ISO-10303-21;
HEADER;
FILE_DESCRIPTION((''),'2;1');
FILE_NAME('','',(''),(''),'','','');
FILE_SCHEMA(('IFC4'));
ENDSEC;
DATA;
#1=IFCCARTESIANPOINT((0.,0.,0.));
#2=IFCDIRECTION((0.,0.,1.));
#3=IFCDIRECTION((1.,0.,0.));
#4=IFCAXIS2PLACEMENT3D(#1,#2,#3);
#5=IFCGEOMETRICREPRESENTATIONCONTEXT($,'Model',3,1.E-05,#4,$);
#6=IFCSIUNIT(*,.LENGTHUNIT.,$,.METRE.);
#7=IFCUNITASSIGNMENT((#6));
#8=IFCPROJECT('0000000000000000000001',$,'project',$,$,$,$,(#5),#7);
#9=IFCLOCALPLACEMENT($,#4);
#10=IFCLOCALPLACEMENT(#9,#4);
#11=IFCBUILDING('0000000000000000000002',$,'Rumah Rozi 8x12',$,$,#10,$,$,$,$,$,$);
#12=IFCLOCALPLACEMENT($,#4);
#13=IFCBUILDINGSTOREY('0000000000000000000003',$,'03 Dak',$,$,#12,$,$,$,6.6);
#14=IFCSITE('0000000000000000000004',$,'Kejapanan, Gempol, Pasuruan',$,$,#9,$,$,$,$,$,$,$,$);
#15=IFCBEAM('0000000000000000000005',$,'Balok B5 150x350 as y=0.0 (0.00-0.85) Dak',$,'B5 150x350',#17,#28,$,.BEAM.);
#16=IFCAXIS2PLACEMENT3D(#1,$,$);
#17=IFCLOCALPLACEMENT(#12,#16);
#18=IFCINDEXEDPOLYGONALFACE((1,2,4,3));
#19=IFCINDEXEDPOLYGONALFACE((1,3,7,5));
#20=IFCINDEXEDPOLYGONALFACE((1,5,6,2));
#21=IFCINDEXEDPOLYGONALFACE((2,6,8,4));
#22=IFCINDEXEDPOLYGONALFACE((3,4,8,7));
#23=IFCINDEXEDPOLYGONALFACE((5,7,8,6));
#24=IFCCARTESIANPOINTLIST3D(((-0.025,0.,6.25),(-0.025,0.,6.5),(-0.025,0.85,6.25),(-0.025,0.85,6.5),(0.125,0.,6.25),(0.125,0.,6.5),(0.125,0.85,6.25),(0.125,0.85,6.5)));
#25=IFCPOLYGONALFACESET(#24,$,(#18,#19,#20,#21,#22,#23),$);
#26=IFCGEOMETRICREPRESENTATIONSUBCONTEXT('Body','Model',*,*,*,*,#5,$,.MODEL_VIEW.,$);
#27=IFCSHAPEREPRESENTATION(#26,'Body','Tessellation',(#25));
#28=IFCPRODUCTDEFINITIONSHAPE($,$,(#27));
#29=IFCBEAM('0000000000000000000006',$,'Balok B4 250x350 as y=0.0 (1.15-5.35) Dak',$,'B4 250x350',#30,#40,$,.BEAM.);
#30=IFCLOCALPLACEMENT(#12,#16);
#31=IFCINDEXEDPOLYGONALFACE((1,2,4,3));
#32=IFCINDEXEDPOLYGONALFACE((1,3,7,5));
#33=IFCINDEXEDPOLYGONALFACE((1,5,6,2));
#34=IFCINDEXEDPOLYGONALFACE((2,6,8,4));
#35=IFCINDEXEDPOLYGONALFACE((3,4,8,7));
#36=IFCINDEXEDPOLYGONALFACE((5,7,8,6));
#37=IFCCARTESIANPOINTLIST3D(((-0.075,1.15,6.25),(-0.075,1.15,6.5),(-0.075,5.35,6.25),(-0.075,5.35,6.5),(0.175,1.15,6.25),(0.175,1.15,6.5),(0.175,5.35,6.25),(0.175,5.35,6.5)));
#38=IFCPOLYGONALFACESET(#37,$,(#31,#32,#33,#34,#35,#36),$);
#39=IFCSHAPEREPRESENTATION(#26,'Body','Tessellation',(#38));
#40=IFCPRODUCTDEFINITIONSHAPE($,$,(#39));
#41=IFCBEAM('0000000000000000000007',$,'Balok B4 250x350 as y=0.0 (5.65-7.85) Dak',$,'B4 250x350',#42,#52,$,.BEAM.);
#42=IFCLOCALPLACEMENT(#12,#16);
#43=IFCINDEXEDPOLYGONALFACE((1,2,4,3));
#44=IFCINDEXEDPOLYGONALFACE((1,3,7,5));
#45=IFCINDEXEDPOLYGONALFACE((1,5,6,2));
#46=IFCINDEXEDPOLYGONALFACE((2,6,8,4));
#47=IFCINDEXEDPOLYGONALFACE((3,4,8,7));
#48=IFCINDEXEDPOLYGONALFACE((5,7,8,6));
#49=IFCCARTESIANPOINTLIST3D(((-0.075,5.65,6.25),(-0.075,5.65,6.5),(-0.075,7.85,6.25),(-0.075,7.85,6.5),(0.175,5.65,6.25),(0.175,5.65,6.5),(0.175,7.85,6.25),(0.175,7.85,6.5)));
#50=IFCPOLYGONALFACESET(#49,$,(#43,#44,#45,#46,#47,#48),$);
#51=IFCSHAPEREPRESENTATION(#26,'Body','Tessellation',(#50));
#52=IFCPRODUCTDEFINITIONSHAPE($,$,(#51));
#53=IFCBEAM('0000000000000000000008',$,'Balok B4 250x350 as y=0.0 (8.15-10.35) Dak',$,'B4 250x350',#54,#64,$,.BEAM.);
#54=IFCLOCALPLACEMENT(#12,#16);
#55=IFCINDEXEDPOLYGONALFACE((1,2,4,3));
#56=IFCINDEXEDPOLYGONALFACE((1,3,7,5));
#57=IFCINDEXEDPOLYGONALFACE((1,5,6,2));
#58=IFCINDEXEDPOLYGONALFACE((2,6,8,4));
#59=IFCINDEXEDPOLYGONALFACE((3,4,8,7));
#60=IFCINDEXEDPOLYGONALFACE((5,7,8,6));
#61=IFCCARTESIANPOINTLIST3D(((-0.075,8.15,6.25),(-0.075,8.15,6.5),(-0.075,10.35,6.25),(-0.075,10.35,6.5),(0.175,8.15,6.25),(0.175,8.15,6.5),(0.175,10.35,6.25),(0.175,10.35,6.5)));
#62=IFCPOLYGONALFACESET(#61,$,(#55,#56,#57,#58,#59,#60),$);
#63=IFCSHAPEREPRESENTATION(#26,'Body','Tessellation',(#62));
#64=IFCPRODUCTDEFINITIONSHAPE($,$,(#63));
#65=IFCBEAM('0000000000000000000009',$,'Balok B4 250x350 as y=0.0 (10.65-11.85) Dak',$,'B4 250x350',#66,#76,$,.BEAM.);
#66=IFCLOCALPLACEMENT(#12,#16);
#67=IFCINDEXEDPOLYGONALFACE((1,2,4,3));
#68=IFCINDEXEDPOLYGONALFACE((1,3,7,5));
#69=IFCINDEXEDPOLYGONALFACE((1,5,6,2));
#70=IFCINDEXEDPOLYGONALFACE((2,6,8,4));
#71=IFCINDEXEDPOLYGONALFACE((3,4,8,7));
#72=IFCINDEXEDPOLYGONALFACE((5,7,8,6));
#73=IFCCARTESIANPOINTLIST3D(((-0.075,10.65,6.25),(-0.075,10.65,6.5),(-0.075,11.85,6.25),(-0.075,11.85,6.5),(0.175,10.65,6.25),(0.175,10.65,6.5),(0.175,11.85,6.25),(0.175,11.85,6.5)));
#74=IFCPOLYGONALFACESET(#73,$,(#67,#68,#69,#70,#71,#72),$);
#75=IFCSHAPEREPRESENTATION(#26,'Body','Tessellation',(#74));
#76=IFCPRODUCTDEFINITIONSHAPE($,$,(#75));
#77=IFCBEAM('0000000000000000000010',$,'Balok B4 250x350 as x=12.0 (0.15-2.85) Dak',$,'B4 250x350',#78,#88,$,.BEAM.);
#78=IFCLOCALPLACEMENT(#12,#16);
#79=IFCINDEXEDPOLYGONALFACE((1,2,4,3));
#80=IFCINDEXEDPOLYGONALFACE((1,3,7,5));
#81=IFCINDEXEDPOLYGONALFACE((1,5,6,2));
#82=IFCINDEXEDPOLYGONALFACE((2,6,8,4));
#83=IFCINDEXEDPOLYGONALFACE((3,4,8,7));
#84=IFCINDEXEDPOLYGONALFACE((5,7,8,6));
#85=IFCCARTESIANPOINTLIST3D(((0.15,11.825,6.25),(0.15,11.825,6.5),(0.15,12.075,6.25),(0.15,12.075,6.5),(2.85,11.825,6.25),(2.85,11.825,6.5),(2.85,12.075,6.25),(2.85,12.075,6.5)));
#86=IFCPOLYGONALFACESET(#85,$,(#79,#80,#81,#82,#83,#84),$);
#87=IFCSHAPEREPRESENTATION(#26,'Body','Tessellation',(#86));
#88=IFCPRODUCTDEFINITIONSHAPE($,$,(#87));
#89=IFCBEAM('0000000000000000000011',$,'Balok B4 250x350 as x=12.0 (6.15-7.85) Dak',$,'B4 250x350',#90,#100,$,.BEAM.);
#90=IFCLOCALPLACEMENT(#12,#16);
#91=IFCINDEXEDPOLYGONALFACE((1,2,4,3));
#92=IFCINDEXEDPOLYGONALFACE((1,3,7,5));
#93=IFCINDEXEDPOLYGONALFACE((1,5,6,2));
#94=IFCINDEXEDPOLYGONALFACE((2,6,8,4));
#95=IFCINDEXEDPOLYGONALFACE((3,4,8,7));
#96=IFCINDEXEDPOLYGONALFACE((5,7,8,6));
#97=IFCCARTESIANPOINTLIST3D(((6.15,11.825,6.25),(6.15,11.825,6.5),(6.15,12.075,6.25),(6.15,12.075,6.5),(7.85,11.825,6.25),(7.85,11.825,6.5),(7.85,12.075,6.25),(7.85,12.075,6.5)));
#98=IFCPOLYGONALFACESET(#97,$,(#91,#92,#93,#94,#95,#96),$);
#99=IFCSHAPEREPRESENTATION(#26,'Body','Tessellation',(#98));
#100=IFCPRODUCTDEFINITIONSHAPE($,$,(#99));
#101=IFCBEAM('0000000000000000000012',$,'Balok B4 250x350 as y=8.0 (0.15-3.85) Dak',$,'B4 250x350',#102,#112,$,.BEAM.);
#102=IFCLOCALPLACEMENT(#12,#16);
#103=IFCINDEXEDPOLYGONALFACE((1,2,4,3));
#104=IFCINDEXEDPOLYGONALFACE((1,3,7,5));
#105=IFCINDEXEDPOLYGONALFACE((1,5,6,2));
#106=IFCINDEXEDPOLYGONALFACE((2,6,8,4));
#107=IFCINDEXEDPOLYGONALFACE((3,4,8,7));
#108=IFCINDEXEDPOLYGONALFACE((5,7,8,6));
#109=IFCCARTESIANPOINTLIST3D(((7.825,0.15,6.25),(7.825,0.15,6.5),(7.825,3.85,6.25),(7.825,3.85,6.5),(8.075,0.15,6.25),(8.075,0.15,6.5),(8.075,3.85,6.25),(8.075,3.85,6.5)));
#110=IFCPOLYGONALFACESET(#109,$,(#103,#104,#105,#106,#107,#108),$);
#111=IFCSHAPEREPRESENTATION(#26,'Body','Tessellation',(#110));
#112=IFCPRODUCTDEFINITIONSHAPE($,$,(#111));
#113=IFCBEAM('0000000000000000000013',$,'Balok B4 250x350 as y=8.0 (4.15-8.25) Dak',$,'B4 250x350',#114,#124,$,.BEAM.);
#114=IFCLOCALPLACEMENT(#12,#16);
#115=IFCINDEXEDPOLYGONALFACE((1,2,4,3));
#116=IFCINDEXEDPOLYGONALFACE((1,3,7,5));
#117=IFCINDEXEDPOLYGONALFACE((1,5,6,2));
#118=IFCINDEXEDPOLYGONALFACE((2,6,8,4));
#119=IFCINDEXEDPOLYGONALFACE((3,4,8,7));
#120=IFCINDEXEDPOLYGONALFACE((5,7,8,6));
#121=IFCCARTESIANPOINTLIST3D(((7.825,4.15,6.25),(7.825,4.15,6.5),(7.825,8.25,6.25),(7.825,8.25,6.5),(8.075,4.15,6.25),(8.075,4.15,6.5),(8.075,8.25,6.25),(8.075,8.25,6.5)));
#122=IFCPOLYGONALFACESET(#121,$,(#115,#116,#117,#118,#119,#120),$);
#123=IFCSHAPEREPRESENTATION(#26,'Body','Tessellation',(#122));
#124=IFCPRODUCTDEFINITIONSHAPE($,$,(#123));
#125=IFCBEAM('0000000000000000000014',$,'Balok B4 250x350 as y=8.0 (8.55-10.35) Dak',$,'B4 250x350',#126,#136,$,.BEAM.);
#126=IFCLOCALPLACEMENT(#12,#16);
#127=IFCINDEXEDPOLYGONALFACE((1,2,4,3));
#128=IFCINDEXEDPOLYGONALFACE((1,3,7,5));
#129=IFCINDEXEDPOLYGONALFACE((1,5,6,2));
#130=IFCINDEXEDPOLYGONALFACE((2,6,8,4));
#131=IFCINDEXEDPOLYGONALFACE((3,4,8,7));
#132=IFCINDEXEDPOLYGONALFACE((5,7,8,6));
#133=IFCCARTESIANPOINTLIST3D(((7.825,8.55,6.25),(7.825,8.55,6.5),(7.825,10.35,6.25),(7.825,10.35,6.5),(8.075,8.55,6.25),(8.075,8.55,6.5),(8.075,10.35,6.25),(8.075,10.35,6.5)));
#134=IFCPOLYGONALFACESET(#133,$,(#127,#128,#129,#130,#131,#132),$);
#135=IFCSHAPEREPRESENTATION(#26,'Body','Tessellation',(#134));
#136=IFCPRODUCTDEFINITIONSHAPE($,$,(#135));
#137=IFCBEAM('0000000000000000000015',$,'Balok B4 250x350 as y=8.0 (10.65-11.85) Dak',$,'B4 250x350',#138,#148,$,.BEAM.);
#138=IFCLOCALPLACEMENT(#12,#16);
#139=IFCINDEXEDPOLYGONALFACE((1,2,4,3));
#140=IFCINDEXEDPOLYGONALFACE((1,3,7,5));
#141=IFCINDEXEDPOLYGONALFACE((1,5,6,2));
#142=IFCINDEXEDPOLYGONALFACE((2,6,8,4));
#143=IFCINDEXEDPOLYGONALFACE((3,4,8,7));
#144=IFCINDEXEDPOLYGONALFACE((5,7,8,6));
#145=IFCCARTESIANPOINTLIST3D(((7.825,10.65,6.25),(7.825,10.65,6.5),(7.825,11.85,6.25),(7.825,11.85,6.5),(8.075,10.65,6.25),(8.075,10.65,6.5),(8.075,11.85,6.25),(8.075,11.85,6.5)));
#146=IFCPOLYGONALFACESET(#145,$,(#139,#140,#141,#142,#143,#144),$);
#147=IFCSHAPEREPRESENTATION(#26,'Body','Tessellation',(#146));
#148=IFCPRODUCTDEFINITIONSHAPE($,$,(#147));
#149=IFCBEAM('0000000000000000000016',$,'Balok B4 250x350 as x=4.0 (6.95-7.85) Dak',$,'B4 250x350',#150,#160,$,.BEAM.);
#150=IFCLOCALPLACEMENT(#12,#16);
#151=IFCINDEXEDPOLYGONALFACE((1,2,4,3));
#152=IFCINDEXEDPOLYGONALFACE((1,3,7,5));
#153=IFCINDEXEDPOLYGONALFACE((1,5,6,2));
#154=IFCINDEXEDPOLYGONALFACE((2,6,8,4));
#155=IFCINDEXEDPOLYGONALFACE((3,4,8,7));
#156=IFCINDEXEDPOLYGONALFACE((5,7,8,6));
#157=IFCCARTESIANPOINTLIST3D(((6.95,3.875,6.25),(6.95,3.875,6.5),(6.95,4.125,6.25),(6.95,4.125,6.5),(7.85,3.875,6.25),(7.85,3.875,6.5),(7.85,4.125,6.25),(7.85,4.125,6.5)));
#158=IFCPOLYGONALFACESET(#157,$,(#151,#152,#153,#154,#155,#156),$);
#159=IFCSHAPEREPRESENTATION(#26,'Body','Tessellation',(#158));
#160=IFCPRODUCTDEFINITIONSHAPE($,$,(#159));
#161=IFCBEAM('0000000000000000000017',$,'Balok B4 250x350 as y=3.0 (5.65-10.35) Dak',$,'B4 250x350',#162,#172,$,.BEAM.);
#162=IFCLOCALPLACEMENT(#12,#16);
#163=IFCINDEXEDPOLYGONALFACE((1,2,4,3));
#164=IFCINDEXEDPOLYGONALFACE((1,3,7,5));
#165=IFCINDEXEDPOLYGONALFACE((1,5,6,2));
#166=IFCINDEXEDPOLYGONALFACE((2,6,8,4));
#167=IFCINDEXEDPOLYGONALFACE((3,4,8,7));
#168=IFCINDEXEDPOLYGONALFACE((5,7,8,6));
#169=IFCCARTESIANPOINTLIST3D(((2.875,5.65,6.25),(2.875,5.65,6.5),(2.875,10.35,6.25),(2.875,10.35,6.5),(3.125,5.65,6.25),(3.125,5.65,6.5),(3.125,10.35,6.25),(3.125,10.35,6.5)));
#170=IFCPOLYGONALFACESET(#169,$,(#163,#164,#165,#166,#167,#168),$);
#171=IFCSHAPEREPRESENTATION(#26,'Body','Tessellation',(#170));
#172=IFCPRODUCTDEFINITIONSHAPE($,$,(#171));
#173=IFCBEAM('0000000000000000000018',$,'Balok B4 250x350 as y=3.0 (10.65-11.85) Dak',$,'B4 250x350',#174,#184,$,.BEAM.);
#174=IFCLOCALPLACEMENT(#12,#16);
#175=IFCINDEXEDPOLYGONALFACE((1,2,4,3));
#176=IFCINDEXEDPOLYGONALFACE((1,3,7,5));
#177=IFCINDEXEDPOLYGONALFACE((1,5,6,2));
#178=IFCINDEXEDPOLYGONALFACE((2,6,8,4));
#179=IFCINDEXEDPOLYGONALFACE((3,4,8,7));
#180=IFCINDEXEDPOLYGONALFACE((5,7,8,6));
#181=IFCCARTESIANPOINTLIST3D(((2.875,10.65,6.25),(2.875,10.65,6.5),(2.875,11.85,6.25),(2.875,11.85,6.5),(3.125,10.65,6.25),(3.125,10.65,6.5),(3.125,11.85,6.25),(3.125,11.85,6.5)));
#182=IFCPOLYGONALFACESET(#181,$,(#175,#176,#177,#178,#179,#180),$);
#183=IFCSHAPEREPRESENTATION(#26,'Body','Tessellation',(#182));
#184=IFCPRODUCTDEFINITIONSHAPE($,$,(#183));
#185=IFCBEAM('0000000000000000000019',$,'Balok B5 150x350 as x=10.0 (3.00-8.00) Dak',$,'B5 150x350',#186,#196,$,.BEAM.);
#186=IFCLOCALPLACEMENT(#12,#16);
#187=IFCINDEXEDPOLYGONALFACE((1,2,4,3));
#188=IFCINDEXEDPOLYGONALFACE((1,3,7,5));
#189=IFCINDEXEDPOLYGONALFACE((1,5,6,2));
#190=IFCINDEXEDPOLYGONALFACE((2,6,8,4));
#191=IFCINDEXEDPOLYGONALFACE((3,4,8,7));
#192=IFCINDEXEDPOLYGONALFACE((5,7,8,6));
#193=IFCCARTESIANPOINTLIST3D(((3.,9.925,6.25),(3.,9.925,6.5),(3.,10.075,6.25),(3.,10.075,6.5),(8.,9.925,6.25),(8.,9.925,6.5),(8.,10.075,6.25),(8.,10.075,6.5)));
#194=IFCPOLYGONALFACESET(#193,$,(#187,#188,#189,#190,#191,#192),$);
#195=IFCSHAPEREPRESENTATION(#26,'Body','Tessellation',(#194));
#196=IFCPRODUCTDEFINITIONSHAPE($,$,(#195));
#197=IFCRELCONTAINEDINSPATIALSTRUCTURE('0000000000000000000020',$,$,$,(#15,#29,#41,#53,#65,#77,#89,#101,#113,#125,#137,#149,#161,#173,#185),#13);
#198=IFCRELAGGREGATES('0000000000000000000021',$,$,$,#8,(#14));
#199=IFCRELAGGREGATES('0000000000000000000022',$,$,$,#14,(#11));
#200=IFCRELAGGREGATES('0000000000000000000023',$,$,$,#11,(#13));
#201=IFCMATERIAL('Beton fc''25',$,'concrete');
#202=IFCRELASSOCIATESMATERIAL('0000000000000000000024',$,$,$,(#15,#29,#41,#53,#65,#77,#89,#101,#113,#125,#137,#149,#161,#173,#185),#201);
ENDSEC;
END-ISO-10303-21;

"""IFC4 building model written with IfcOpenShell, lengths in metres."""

from ifc_helpers import new_model, si_unit, frame, origin_with_axes, place, context, subcontext, project, spatial, line, indexed_curve, outline, extrude, material, element, save


model = new_model("IFC4")

# Units and contexts
model_context = context("Model", 3, precision=1e-05, world=origin_with_axes())
body_context = subcontext(model_context, "Body", "Model", "MODEL_VIEW")
ifc_project = project(units=[si_unit("LENGTHUNIT", "METRE")], contexts=[model_context])

# Site, building, storey
site_placement = place(None, origin_with_axes())
site = spatial("IfcSite", under=ifc_project, at=site_placement, Name="Kejapanan, Gempol, Pasuruan")
building_placement = place(site_placement, origin_with_axes())
building = spatial("IfcBuilding", under=site, at=building_placement, Name="Rumah Rozi 8x12")
storey_placement = place(None, origin_with_axes())
storey = spatial("IfcBuildingStorey", under=building, at=storey_placement, Name="03 Dak", Elevation=6.6)

# Beams
ifc_material = material(Name="Beton fc'25", Category="concrete")
beam_1_placement = place(storey_placement, origin_with_axes())
element("IfcBeam", 1, at=beam_1_placement, inside=storey, material=ifc_material, Name="Balok B5 150x350 as y=0.0 (0.00-0.85) Dak", ObjectType="B5 150x350", PredefinedType="BEAM", context=body_context, shape_type="SweptSolid", body=[
    extrude(outline(indexed_curve([(-0.025, 0.0), (0.125, 0.0), (0.125, 0.85), (-0.025, 0.85)], segments=[line(1, 2, 3, 4, 1)])), frame((0.0, 0.0, 6.25), z_axis=(0.0, 0.0, 1.0), x_axis=(1.0, 0.0, 0.0)), (0.0, 0.0, 1.0), 0.25),
])
beam_2_placement = place(storey_placement, origin_with_axes())
element("IfcBeam", 2, at=beam_2_placement, inside=storey, material=ifc_material, Name="Balok B4 250x350 as y=0.0 (1.15-5.35) Dak", ObjectType="B4 250x350", PredefinedType="BEAM", context=body_context, shape_type="SweptSolid", body=[
    extrude(outline(indexed_curve([(-0.075, 1.15), (0.175, 1.15), (0.175, 5.35), (-0.075, 5.35)], segments=[line(1, 2, 3, 4, 1)])), frame((0.0, 0.0, 6.25), z_axis=(0.0, 0.0, 1.0), x_axis=(1.0, 0.0, 0.0)), (0.0, 0.0, 1.0), 0.25),
])
beam_3_placement = place(storey_placement, origin_with_axes())
element("IfcBeam", 3, at=beam_3_placement, inside=storey, material=ifc_material, Name="Balok B4 250x350 as y=0.0 (5.65-7.85) Dak", ObjectType="B4 250x350", PredefinedType="BEAM", context=body_context, shape_type="SweptSolid", body=[
    extrude(outline(indexed_curve([(-0.075, 5.65), (0.175, 5.65), (0.175, 7.85), (-0.075, 7.85)], segments=[line(1, 2, 3, 4, 1)])), frame((0.0, 0.0, 6.25), z_axis=(0.0, 0.0, 1.0), x_axis=(1.0, 0.0, 0.0)), (0.0, 0.0, 1.0), 0.25),
])
beam_4_placement = place(storey_placement, origin_with_axes())
element("IfcBeam", 4, at=beam_4_placement, inside=storey, material=ifc_material, Name="Balok B4 250x350 as y=0.0 (8.15-10.35) Dak", ObjectType="B4 250x350", PredefinedType="BEAM", context=body_context, shape_type="SweptSolid", body=[
    extrude(outline(indexed_curve([(-0.075, 8.15), (0.175, 8.15), (0.175, 10.35), (-0.075, 10.35)], segments=[line(1, 2, 3, 4, 1)])), frame((0.0, 0.0, 6.25), z_axis=(0.0, 0.0, 1.0), x_axis=(1.0, 0.0, 0.0)), (0.0, 0.0, 1.0), 0.25),
])
beam_5_placement = place(storey_placement, origin_with_axes())
element("IfcBeam", 5, at=beam_5_placement, inside=storey, material=ifc_material, Name="Balok B4 250x350 as y=0.0 (10.65-11.85) Dak", ObjectType="B4 250x350", PredefinedType="BEAM", context=body_context, shape_type="SweptSolid", body=[
    extrude(outline(indexed_curve([(-0.075, 10.65), (0.175, 10.65), (0.175, 11.85), (-0.075, 11.85)], segments=[line(1, 2, 3, 4, 1)])), frame((0.0, 0.0, 6.25), z_axis=(0.0, 0.0, 1.0), x_axis=(1.0, 0.0, 0.0)), (0.0, 0.0, 1.0), 0.25),
])
beam_6_placement = place(storey_placement, origin_with_axes())
element("IfcBeam", 6, at=beam_6_placement, inside=storey, material=ifc_material, Name="Balok B4 250x350 as x=12.0 (0.15-2.85) Dak", ObjectType="B4 250x350", PredefinedType="BEAM", context=body_context, shape_type="SweptSolid", body=[
    extrude(outline(indexed_curve([(0.15, 11.825), (2.85, 11.825), (2.85, 12.075), (0.15, 12.075)], segments=[line(1, 2, 3, 4, 1)])), frame((0.0, 0.0, 6.25), z_axis=(0.0, 0.0, 1.0), x_axis=(1.0, 0.0, 0.0)), (0.0, 0.0, 1.0), 0.25),
])
beam_7_placement = place(storey_placement, origin_with_axes())
element("IfcBeam", 7, at=beam_7_placement, inside=storey, material=ifc_material, Name="Balok B4 250x350 as x=12.0 (6.15-7.85) Dak", ObjectType="B4 250x350", PredefinedType="BEAM", context=body_context, shape_type="SweptSolid", body=[
    extrude(outline(indexed_curve([(6.15, 11.825), (7.85, 11.825), (7.85, 12.075), (6.15, 12.075)], segments=[line(1, 2, 3, 4, 1)])), frame((0.0, 0.0, 6.25), z_axis=(0.0, 0.0, 1.0), x_axis=(1.0, 0.0, 0.0)), (0.0, 0.0, 1.0), 0.25),
])
beam_8_placement = place(storey_placement, origin_with_axes())
element("IfcBeam", 8, at=beam_8_placement, inside=storey, material=ifc_material, Name="Balok B4 250x350 as y=8.0 (0.15-3.85) Dak", ObjectType="B4 250x350", PredefinedType="BEAM", context=body_context, shape_type="SweptSolid", body=[
    extrude(outline(indexed_curve([(7.825, 0.15), (8.075, 0.15), (8.075, 3.85), (7.825, 3.85)], segments=[line(1, 2, 3, 4, 1)])), frame((0.0, 0.0, 6.25), z_axis=(0.0, 0.0, 1.0), x_axis=(1.0, 0.0, 0.0)), (0.0, 0.0, 1.0), 0.25),
])
beam_9_placement = place(storey_placement, origin_with_axes())
element("IfcBeam", 9, at=beam_9_placement, inside=storey, material=ifc_material, Name="Balok B4 250x350 as y=8.0 (4.15-8.25) Dak", ObjectType="B4 250x350", PredefinedType="BEAM", context=body_context, shape_type="SweptSolid", body=[
    extrude(outline(indexed_curve([(7.825, 4.15), (8.075, 4.15), (8.075, 8.25), (7.825, 8.25)], segments=[line(1, 2, 3, 4, 1)])), frame((0.0, 0.0, 6.25), z_axis=(0.0, 0.0, 1.0), x_axis=(1.0, 0.0, 0.0)), (0.0, 0.0, 1.0), 0.25),
])
beam_10_placement = place(storey_placement, origin_with_axes())
element("IfcBeam", 10, at=beam_10_placement, inside=storey, material=ifc_material, Name="Balok B4 250x350 as y=8.0 (8.55-10.35) Dak", ObjectType="B4 250x350", PredefinedType="BEAM", context=body_context, shape_type="SweptSolid", body=[
    extrude(outline(indexed_curve([(7.825, 8.55), (8.075, 8.55), (8.075, 10.35), (7.825, 10.35)], segments=[line(1, 2, 3, 4, 1)])), frame((0.0, 0.0, 6.25), z_axis=(0.0, 0.0, 1.0), x_axis=(1.0, 0.0, 0.0)), (0.0, 0.0, 1.0), 0.25),
])
beam_11_placement = place(storey_placement, origin_with_axes())
element("IfcBeam", 11, at=beam_11_placement, inside=storey, material=ifc_material, Name="Balok B4 250x350 as y=8.0 (10.65-11.85) Dak", ObjectType="B4 250x350", PredefinedType="BEAM", context=body_context, shape_type="SweptSolid", body=[
    extrude(outline(indexed_curve([(7.825, 10.65), (8.075, 10.65), (8.075, 11.85), (7.825, 11.85)], segments=[line(1, 2, 3, 4, 1)])), frame((0.0, 0.0, 6.25), z_axis=(0.0, 0.0, 1.0), x_axis=(1.0, 0.0, 0.0)), (0.0, 0.0, 1.0), 0.25),
])
beam_12_placement = place(storey_placement, origin_with_axes())
element("IfcBeam", 12, at=beam_12_placement, inside=storey, material=ifc_material, Name="Balok B4 250x350 as x=4.0 (6.95-7.85) Dak", ObjectType="B4 250x350", PredefinedType="BEAM", context=body_context, shape_type="SweptSolid", body=[
    extrude(outline(indexed_curve([(6.95, 3.875), (7.85, 3.875), (7.85, 4.125), (6.95, 4.125)], segments=[line(1, 2, 3, 4, 1)])), frame((0.0, 0.0, 6.25), z_axis=(0.0, 0.0, 1.0), x_axis=(1.0, 0.0, 0.0)), (0.0, 0.0, 1.0), 0.25),
])
beam_13_placement = place(storey_placement, origin_with_axes())
element("IfcBeam", 13, at=beam_13_placement, inside=storey, material=ifc_material, Name="Balok B4 250x350 as y=3.0 (5.65-10.35) Dak", ObjectType="B4 250x350", PredefinedType="BEAM", context=body_context, shape_type="SweptSolid", body=[
    extrude(outline(indexed_curve([(2.875, 5.65), (3.125, 5.65), (3.125, 10.35), (2.875, 10.35)], segments=[line(1, 2, 3, 4, 1)])), frame((0.0, 0.0, 6.25), z_axis=(0.0, 0.0, 1.0), x_axis=(1.0, 0.0, 0.0)), (0.0, 0.0, 1.0), 0.25),
])
beam_14_placement = place(storey_placement, origin_with_axes())
element("IfcBeam", 14, at=beam_14_placement, inside=storey, material=ifc_material, Name="Balok B4 250x350 as y=3.0 (10.65-11.85) Dak", ObjectType="B4 250x350", PredefinedType="BEAM", context=body_context, shape_type="SweptSolid", body=[
    extrude(outline(indexed_curve([(2.875, 10.65), (3.125, 10.65), (3.125, 11.85), (2.875, 11.85)], segments=[line(1, 2, 3, 4, 1)])), frame((0.0, 0.0, 6.25), z_axis=(0.0, 0.0, 1.0), x_axis=(1.0, 0.0, 0.0)), (0.0, 0.0, 1.0), 0.25),
])
beam_15_placement = place(storey_placement, origin_with_axes())
element("IfcBeam", 15, at=beam_15_placement, inside=storey, material=ifc_material, Name="Balok B5 150x350 as x=10.0 (3.00-8.00) Dak", ObjectType="B5 150x350", PredefinedType="BEAM", context=body_context, shape_type="SweptSolid", body=[
    extrude(outline(indexed_curve([(3.0, 9.925), (8.0, 9.925), (8.0, 10.075), (3.0, 10.075)], segments=[line(1, 2, 3, 4, 1)])), frame((0.0, 0.0, 6.25), z_axis=(0.0, 0.0, 1.0), x_axis=(1.0, 0.0, 0.0)), (0.0, 0.0, 1.0), 0.25),
])

save(model, "model.ifc")
